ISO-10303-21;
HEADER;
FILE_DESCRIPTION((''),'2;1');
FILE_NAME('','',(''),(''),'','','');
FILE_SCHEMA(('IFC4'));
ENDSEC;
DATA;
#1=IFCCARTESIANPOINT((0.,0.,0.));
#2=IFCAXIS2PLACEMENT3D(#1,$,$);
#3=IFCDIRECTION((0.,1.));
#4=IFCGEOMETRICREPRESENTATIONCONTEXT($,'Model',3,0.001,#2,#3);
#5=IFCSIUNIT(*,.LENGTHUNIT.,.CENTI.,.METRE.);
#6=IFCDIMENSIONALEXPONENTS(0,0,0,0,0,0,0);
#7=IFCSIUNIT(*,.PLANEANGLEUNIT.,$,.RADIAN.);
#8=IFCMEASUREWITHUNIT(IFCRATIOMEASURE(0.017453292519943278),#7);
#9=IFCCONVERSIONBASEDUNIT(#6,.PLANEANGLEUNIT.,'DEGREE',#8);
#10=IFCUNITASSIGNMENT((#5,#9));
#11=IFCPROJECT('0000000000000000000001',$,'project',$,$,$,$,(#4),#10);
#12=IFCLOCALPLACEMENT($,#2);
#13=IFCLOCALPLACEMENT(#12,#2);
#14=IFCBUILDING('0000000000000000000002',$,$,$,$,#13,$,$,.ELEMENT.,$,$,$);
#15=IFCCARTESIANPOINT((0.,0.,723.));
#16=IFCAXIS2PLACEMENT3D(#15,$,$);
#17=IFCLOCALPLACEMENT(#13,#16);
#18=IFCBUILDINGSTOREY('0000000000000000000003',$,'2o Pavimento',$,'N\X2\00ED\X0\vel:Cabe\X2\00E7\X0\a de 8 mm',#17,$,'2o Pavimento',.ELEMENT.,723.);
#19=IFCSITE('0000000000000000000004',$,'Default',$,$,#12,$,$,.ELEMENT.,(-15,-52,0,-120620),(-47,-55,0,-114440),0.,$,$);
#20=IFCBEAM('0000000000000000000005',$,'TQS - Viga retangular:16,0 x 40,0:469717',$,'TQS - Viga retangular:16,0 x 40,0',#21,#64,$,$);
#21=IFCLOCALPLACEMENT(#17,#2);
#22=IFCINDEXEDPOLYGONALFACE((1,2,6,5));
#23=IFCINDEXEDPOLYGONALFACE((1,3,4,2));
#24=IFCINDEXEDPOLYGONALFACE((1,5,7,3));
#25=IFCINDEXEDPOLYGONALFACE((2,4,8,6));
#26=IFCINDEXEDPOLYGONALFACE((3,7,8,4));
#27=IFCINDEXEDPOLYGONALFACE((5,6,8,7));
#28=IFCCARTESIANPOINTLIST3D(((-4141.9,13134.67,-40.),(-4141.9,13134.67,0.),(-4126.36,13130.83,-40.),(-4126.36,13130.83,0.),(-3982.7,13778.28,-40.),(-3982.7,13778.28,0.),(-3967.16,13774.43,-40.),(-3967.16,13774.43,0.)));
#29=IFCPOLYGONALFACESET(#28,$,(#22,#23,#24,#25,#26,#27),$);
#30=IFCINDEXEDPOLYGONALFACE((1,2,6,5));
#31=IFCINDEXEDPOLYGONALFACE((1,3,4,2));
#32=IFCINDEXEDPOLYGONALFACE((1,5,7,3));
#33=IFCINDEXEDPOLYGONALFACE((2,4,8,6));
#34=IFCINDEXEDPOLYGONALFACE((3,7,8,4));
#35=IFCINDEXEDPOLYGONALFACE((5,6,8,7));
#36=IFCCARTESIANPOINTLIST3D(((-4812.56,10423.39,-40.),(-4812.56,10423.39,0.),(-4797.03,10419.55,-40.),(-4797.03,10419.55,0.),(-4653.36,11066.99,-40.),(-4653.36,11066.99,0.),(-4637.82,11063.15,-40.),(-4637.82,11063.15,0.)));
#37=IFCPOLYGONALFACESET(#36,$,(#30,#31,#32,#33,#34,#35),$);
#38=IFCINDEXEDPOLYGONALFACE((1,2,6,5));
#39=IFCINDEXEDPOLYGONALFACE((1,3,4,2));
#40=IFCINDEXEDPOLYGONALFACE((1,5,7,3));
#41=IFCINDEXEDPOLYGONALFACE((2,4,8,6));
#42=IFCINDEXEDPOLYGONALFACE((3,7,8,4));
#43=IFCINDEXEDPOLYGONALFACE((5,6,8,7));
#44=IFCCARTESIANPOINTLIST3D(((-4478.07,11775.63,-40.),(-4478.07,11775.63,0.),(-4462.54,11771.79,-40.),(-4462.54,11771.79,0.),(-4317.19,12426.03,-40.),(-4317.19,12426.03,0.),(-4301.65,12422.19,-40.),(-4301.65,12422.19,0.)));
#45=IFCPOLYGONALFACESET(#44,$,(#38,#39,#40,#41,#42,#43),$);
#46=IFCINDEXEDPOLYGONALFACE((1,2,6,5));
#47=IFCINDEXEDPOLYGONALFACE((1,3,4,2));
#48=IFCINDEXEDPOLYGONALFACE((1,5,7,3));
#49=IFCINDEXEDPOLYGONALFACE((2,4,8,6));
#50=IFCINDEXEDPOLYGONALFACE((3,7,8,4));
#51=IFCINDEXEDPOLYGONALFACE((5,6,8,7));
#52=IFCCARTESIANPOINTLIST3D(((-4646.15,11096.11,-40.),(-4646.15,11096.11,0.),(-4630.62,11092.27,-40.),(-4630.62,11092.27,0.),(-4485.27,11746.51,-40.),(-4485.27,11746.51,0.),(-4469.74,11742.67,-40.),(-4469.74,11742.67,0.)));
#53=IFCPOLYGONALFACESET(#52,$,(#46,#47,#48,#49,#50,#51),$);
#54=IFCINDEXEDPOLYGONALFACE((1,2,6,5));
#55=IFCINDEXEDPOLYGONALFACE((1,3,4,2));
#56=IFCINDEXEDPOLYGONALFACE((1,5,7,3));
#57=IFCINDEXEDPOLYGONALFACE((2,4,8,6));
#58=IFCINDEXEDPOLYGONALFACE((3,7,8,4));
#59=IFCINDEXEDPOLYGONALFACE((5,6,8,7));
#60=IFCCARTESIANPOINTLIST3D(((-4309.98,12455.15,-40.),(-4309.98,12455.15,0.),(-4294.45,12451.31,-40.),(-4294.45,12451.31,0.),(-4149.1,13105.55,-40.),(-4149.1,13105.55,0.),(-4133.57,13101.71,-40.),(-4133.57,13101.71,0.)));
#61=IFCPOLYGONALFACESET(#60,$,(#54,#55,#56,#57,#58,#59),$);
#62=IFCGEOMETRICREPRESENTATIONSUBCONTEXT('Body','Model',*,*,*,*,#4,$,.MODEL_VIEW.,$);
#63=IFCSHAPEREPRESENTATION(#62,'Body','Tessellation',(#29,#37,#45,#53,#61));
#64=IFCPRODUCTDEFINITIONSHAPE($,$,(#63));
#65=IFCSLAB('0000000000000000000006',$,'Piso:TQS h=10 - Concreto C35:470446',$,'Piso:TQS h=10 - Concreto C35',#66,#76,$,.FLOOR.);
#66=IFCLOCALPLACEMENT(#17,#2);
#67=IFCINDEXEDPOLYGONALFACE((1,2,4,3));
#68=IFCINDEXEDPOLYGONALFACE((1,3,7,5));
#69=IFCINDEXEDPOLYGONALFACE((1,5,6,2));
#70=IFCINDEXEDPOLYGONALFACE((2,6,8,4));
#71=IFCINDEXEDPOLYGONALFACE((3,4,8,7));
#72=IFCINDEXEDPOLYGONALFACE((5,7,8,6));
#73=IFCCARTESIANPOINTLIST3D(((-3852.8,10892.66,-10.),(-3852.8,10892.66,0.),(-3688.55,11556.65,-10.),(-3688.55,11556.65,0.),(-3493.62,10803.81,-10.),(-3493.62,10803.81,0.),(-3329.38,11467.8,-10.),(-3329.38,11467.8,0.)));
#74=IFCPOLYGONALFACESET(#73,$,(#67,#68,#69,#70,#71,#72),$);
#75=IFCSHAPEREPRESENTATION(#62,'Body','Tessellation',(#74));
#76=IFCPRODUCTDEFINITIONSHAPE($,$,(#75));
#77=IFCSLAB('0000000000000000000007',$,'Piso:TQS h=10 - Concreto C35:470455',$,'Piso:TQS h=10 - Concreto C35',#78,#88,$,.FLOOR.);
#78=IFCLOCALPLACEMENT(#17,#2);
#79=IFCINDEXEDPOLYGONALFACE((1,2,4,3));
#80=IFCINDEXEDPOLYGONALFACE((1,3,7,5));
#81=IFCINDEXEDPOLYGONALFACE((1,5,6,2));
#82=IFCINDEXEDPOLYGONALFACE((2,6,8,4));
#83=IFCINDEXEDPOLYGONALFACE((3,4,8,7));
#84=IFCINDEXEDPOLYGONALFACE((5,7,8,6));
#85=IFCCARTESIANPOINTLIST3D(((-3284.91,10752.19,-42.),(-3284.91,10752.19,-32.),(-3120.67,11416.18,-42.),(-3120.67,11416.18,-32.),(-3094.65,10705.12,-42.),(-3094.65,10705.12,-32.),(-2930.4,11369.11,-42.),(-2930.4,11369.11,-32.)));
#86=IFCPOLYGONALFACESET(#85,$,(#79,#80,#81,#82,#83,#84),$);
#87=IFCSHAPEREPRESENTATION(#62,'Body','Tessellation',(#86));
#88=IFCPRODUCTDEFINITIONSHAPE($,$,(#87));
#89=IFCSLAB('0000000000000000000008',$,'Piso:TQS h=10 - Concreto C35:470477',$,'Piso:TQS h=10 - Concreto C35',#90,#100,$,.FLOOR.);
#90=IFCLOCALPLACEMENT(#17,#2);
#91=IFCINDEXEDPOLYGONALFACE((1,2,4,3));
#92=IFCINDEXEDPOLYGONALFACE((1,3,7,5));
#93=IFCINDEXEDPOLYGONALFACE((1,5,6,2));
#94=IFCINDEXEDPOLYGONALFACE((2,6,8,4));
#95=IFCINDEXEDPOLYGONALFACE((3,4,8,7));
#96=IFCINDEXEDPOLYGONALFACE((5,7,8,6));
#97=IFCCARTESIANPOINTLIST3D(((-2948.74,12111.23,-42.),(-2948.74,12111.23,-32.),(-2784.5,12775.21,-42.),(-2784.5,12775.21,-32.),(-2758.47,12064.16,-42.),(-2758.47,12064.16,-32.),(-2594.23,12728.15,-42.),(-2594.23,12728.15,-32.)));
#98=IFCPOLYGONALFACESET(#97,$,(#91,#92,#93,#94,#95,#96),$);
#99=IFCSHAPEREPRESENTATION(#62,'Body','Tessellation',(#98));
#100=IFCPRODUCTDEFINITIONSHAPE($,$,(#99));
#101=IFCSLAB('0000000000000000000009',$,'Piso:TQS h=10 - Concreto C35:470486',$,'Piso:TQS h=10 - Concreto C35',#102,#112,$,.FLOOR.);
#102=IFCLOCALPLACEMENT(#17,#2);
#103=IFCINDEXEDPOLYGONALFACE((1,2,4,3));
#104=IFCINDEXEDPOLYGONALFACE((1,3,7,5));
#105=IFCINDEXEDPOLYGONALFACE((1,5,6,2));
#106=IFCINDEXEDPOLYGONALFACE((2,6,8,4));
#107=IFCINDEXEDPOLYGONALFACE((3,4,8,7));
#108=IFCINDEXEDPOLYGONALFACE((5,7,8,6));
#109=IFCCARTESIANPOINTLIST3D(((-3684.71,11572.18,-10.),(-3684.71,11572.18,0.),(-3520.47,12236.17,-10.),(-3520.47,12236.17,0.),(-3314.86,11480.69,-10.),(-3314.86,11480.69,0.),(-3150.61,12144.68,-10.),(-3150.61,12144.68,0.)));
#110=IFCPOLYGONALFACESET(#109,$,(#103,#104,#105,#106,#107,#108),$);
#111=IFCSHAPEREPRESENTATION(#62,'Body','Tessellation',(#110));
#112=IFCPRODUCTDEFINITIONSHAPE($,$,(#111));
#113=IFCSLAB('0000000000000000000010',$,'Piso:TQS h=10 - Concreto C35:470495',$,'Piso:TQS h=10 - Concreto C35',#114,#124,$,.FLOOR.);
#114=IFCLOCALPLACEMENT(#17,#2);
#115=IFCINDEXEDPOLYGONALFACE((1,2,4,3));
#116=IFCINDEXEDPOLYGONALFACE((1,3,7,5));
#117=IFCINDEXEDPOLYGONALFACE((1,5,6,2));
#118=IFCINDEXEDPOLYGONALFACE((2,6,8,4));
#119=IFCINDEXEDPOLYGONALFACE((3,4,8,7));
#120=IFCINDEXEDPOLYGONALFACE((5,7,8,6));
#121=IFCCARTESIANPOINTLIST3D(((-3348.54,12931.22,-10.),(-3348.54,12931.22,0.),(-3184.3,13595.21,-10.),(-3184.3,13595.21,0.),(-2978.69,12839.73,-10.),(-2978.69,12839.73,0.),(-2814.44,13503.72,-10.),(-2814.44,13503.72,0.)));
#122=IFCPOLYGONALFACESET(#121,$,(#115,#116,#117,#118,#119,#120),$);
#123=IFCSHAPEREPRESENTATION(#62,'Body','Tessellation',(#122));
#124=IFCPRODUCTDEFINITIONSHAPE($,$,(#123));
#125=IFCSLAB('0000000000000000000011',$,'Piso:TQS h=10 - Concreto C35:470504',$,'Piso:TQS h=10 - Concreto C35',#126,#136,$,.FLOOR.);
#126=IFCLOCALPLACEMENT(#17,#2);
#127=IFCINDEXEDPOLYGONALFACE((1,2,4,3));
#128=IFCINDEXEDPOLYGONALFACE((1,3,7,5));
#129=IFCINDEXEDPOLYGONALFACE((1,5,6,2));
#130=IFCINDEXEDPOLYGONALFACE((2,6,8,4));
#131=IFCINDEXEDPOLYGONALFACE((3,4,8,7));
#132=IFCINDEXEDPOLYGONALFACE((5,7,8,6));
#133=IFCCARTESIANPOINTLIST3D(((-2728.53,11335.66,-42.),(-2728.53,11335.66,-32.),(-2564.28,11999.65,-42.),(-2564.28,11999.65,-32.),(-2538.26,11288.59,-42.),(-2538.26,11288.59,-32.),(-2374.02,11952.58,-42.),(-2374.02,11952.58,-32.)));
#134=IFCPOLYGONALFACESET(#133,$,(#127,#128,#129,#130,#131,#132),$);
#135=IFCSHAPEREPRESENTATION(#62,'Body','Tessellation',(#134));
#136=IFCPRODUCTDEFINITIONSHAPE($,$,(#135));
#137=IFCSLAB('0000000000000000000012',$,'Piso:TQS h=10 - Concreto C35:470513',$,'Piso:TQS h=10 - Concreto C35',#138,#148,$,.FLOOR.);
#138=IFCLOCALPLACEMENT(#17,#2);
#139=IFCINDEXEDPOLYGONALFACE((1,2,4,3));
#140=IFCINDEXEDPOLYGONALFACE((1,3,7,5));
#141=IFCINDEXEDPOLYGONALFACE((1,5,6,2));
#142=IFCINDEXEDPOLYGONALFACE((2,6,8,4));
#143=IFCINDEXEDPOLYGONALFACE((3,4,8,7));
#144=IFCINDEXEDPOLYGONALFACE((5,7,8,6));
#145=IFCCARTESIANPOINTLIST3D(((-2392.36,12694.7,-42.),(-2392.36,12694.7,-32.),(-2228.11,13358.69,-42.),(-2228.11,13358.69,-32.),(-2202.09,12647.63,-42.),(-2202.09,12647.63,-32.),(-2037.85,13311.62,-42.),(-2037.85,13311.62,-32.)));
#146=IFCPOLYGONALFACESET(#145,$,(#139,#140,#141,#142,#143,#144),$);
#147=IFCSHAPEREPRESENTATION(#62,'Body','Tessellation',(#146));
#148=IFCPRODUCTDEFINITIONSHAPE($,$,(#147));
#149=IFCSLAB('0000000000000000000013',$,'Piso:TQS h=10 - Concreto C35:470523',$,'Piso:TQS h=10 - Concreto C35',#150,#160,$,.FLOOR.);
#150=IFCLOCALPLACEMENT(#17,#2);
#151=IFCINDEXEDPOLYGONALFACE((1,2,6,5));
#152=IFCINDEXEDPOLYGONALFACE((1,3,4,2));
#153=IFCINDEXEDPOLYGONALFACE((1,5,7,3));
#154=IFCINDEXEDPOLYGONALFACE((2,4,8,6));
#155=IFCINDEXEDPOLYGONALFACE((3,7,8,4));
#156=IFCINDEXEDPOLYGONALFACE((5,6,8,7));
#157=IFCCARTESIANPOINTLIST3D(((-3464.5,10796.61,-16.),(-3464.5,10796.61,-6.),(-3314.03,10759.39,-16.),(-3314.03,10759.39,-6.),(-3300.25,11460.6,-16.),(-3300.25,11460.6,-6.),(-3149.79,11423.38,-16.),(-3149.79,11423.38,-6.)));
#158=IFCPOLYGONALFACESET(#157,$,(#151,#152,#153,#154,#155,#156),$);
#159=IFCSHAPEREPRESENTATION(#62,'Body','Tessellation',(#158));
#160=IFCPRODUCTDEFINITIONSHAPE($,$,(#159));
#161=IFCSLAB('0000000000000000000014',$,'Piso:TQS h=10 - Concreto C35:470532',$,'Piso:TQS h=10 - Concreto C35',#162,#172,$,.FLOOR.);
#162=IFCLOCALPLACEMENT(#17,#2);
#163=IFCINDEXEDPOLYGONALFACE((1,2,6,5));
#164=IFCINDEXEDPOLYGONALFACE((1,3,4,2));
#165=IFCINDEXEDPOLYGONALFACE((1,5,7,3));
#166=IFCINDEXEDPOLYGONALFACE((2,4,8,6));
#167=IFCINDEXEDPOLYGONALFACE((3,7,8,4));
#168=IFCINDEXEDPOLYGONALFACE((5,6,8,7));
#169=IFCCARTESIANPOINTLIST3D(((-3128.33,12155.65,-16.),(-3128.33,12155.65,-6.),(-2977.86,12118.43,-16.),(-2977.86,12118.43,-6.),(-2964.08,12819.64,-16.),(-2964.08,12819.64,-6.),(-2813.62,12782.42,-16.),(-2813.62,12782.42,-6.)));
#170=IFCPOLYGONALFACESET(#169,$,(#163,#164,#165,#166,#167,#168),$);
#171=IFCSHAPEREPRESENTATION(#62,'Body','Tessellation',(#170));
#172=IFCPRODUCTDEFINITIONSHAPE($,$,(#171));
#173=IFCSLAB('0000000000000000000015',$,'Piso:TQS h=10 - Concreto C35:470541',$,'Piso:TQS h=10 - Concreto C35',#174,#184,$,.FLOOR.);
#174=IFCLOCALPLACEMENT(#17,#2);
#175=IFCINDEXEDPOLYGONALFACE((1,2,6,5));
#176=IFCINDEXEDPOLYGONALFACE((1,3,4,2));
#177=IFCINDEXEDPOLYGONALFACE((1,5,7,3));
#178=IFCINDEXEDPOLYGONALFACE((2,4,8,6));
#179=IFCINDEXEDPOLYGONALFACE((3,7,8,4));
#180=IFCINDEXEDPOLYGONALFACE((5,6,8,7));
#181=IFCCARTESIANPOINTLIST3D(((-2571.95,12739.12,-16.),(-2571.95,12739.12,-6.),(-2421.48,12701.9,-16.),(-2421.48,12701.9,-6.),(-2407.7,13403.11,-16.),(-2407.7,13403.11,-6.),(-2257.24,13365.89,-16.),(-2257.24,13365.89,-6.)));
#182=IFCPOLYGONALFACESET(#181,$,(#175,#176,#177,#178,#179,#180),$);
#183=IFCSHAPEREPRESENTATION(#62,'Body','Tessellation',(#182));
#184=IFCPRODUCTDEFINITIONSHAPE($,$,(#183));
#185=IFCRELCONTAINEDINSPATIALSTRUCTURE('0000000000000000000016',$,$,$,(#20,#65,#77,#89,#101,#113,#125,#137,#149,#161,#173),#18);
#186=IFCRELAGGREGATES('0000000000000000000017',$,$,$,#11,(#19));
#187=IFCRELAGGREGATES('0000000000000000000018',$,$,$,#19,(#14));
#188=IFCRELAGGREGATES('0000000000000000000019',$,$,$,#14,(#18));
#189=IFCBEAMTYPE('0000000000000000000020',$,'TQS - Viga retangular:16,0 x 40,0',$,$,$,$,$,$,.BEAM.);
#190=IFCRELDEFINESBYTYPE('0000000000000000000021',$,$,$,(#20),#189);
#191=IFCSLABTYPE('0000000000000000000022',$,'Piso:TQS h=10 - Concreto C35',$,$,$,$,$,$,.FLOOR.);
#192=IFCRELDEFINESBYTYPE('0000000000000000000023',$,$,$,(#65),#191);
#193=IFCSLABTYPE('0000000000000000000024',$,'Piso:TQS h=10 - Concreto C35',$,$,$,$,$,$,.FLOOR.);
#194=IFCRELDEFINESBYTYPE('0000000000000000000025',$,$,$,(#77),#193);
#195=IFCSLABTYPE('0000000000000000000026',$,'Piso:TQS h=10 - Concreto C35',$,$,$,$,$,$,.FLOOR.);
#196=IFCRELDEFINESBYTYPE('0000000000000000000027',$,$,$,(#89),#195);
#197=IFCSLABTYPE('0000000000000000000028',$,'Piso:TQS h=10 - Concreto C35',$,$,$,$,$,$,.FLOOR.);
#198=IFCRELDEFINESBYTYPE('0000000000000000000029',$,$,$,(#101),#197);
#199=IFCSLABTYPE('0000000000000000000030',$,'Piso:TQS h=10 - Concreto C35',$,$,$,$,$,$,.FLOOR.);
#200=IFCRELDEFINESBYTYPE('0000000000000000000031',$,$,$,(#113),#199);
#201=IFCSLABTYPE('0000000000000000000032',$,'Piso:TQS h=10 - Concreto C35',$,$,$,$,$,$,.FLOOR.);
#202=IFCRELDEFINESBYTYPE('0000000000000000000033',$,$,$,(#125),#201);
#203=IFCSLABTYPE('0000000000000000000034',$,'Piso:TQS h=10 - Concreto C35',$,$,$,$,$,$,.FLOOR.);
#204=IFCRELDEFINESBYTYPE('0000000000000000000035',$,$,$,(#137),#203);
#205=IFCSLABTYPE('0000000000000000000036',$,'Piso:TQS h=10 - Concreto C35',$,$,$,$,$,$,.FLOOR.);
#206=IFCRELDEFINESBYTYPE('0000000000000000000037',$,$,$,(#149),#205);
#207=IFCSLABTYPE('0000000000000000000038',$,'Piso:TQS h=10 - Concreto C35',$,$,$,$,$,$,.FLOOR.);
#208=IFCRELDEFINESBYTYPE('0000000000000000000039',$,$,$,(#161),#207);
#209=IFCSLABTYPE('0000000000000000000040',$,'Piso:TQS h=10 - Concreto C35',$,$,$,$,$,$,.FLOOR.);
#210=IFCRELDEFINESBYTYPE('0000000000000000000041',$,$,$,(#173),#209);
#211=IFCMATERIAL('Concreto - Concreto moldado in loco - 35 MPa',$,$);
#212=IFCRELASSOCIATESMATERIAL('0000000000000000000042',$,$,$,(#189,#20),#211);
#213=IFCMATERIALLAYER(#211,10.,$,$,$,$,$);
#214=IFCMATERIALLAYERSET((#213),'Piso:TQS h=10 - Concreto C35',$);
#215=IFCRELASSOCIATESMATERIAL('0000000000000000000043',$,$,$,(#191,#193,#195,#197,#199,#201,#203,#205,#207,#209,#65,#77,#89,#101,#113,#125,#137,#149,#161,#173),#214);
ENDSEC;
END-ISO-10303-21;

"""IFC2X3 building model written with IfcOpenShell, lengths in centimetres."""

from ifc_helpers import new_model, entity, si_unit, converted_unit, direction, frame, frame_2d, origin, origin_2d_with_axis, place, context, subcontext, project, spatial, rectangle, extrude, source, transform, mapped, material, layer, layer_set, layer_usage, type_object, type_shapes, element, save


model = new_model("IFC2X3")

# Units and contexts
model_context = context("Model", 3, precision=0.001, world=origin(), true_north=direction((0.0, 1.0)))
body_context = subcontext(model_context, "Body", "Model", "MODEL_VIEW")
ifc_project = project(units=[si_unit("LENGTHUNIT", "METRE", prefix="CENTI"), converted_unit("PLANEANGLEUNIT", "DEGREE", entity("IfcRatioMeasure", 0.017453292519943278), si_unit("PLANEANGLEUNIT", "RADIAN"), dimensions=[0, 0, 0, 0, 0, 0, 0])], contexts=[model_context])

# Site, building, storey
site_placement = place(None, origin())
site = spatial("IfcSite", under=ifc_project, at=site_placement, Name="Default", CompositionType="ELEMENT", RefLatitude=(-15, -52, 0, -120620), RefLongitude=(-47, -55, 0, -114440), RefElevation=0.0)
building_placement = place(site_placement, origin())
building = spatial("IfcBuilding", under=site, at=building_placement, CompositionType="ELEMENT")
storey_placement = place(building_placement, frame((0.0, 0.0, 723.0)))
storey = spatial("IfcBuildingStorey", under=building, at=storey_placement, Name="2o Pavimento", ObjectType="Nível:Cabeça de 8 mm", LongName="2o Pavimento", CompositionType="ELEMENT", Elevation=723.0)

# Beam
ifc_material = material(Name="Concreto - Concreto moldado in loco - 35 MPa")
beam_type_1 = type_object("IfcBeamType", Name="TQS - Viga retangular:16,0 x 40,0", PredefinedType="BEAM", material=ifc_material)
shared_shape_1 = source(origin(), body_context, "Body", "SweptSolid", [
    extrude(rectangle(XDim=40.0, YDim=16.0, at=frame_2d((0.0, 0.0), x_axis=(1.0, 0.0))), frame((-4134.13, 13132.75, 703.0), z_axis=(0.240122, 0.970743, 0.0), x_axis=(0.0, 0.0, 1.0)), (0.0, 0.0, 1.0), 663.0),
    extrude(rectangle(XDim=40.0, YDim=16.0, at=frame_2d((0.0, 0.0), x_axis=(1.0, 0.0))), frame((-4804.79, 10421.47, 703.0), z_axis=(0.240122, 0.970743, 0.0), x_axis=(0.0, 0.0, 1.0)), (0.0, 0.0, 1.0), 663.0),
    extrude(rectangle(XDim=40.0, YDim=16.0, at=frame_2d((0.0, 0.0), x_axis=(1.0, 0.0))), frame((-4470.3, 11773.71, 703.0), z_axis=(0.240122, 0.970743, 0.0), x_axis=(0.0, 0.0, 1.0)), (0.0, 0.0, 1.0), 670.0),
    extrude(rectangle(XDim=40.0, YDim=16.0, at=frame_2d((0.0, 0.0), x_axis=(1.0, 0.0))), frame((-4638.39, 11094.19, 703.0), z_axis=(0.240122, 0.970743, 0.0), x_axis=(0.0, 0.0, 1.0)), (0.0, 0.0, 1.0), 670.0),
    extrude(rectangle(XDim=40.0, YDim=16.0, at=frame_2d((0.0, 0.0), x_axis=(1.0, 0.0))), frame((-4302.22, 12453.23, 703.0), z_axis=(0.240122, 0.970743, 0.0), x_axis=(0.0, 0.0, 1.0)), (0.0, 0.0, 1.0), 670.0),
])
type_shapes(beam_type_1, [shared_shape_1])
beam_1_placement = place(storey_placement, frame((0.0, 0.0, -723.0)))
element("IfcBeam", 1, at=beam_1_placement, inside=storey, type_object=beam_type_1, material=ifc_material, Name="TQS - Viga retangular:16,0 x 40,0:469717", ObjectType="TQS - Viga retangular:16,0 x 40,0", context=body_context, shape_type="MappedRepresentation", body=[
    mapped(shared_shape_1, transform((0.0, 0.0, 0.0), scale=1.0)),
])

# Slabs
ifc_layer = layer(ifc_material, 10.0)
ifc_layer_set = layer_set([ifc_layer], Name="Piso:TQS h=10 - Concreto C35")
ifc_layer_usage_1 = layer_usage(ifc_layer_set, "AXIS3", "POSITIVE", 0.0)
slab_type_1 = type_object("IfcSlabType", Name="Piso:TQS h=10 - Concreto C35", PredefinedType="FLOOR", material=ifc_layer_set)
slab_1_placement = place(storey_placement, origin())
element("IfcSlab", 2, at=slab_1_placement, inside=storey, type_object=slab_type_1, material=ifc_layer_usage_1, Name="Piso:TQS h=10 - Concreto C35:470446", ObjectType="Piso:TQS h=10 - Concreto C35", PredefinedType="FLOOR", context=body_context, shape_type="SweptSolid", body=[
    extrude(rectangle(XDim=684.0, YDim=370.0, at=frame_2d((0.0, 0.0), x_axis=(1.0, 0.0))), frame((-3591.09, 11180.23, 0.0), z_axis=(0.0, 0.0, -1.0), x_axis=(-0.240122, -0.970743, 0.0)), (0.0, 0.0, 1.0), 10.0),
])
ifc_layer_usage_2 = layer_usage(ifc_layer_set, "AXIS3", "POSITIVE", 0.0)
slab_type_2 = type_object("IfcSlabType", Name="Piso:TQS h=10 - Concreto C35", PredefinedType="FLOOR", material=ifc_layer_set)
slab_2_placement = place(storey_placement, origin())
element("IfcSlab", 3, at=slab_2_placement, inside=storey, type_object=slab_type_2, material=ifc_layer_usage_2, Name="Piso:TQS h=10 - Concreto C35:470455", ObjectType="Piso:TQS h=10 - Concreto C35", PredefinedType="FLOOR", context=body_context, shape_type="SweptSolid", body=[
    extrude(rectangle(XDim=684.0, YDim=196.0, at=frame_2d((0.0, 0.0), x_axis=(1.0, 0.0))), frame((-3107.66, 11060.65, -32.0), z_axis=(0.0, 0.0, -1.0), x_axis=(-0.240122, -0.970743, 0.0)), (0.0, 0.0, 1.0), 10.0),
])
ifc_layer_usage_3 = layer_usage(ifc_layer_set, "AXIS3", "POSITIVE", 0.0)
slab_type_3 = type_object("IfcSlabType", Name="Piso:TQS h=10 - Concreto C35", PredefinedType="FLOOR", material=ifc_layer_set)
slab_3_placement = place(storey_placement, origin())
element("IfcSlab", 4, at=slab_3_placement, inside=storey, type_object=slab_type_3, material=ifc_layer_usage_3, Name="Piso:TQS h=10 - Concreto C35:470477", ObjectType="Piso:TQS h=10 - Concreto C35", PredefinedType="FLOOR", context=body_context, shape_type="SweptSolid", body=[
    extrude(rectangle(XDim=684.0, YDim=196.0, at=frame_2d((0.0, 0.0), x_axis=(1.0, 0.0))), frame((-2771.49, 12419.69, -32.0), z_axis=(0.0, 0.0, -1.0), x_axis=(-0.240122, -0.970743, 0.0)), (0.0, 0.0, 1.0), 10.0),
])
ifc_layer_usage_4 = layer_usage(ifc_layer_set, "AXIS3", "POSITIVE", 0.0)
slab_type_4 = type_object("IfcSlabType", Name="Piso:TQS h=10 - Concreto C35", PredefinedType="FLOOR", material=ifc_layer_set)
slab_4_placement = place(storey_placement, origin())
element("IfcSlab", 5, at=slab_4_placement, inside=storey, type_object=slab_type_4, material=ifc_layer_usage_4, Name="Piso:TQS h=10 - Concreto C35:470486", ObjectType="Piso:TQS h=10 - Concreto C35", PredefinedType="FLOOR", context=body_context, shape_type="SweptSolid", body=[
    extrude(rectangle(XDim=684.0, YDim=381.0, at=frame_2d((0.0, 0.0), x_axis=(1.0, 0.0))), frame((-3417.66, 11858.43, 0.0), z_axis=(0.0, 0.0, -1.0), x_axis=(-0.240122, -0.970743, 0.0)), (0.0, 0.0, 1.0), 10.0),
])
ifc_layer_usage_5 = layer_usage(ifc_layer_set, "AXIS3", "POSITIVE", 0.0)
slab_type_5 = type_object("IfcSlabType", Name="Piso:TQS h=10 - Concreto C35", PredefinedType="FLOOR", material=ifc_layer_set)
slab_5_placement = place(storey_placement, origin())
element("IfcSlab", 6, at=slab_5_placement, inside=storey, type_object=slab_type_5, material=ifc_layer_usage_5, Name="Piso:TQS h=10 - Concreto C35:470495", ObjectType="Piso:TQS h=10 - Concreto C35", PredefinedType="FLOOR", context=body_context, shape_type="SweptSolid", body=[
    extrude(rectangle(XDim=381.0, YDim=684.0, at=origin_2d_with_axis()), frame((-3081.49, 13217.47, 0.0), z_axis=(0.0, 0.0, -1.0), x_axis=(0.970743, -0.240122, 0.0)), (0.0, 0.0, 1.0), 10.0),
])
ifc_layer_usage_6 = layer_usage(ifc_layer_set, "AXIS3", "POSITIVE", 0.0)
slab_type_6 = type_object("IfcSlabType", Name="Piso:TQS h=10 - Concreto C35", PredefinedType="FLOOR", material=ifc_layer_set)
slab_6_placement = place(storey_placement, origin())
element("IfcSlab", 7, at=slab_6_placement, inside=storey, type_object=slab_type_6, material=ifc_layer_usage_6, Name="Piso:TQS h=10 - Concreto C35:470504", ObjectType="Piso:TQS h=10 - Concreto C35", PredefinedType="FLOOR", context=body_context, shape_type="SweptSolid", body=[
    extrude(rectangle(XDim=684.0, YDim=196.0, at=frame_2d((0.0, 0.0), x_axis=(1.0, 0.0))), frame((-2551.27, 11644.12, -32.0), z_axis=(0.0, 0.0, -1.0), x_axis=(-0.240122, -0.970743, 0.0)), (0.0, 0.0, 1.0), 10.0),
])
ifc_layer_usage_7 = layer_usage(ifc_layer_set, "AXIS3", "POSITIVE", 0.0)
slab_type_7 = type_object("IfcSlabType", Name="Piso:TQS h=10 - Concreto C35", PredefinedType="FLOOR", material=ifc_layer_set)
slab_7_placement = place(storey_placement, origin())
element("IfcSlab", 8, at=slab_7_placement, inside=storey, type_object=slab_type_7, material=ifc_layer_usage_7, Name="Piso:TQS h=10 - Concreto C35:470513", ObjectType="Piso:TQS h=10 - Concreto C35", PredefinedType="FLOOR", context=body_context, shape_type="SweptSolid", body=[
    extrude(rectangle(XDim=684.0, YDim=196.0, at=frame_2d((0.0, 0.0), x_axis=(1.0, 0.0))), frame((-2215.1, 13003.16, -32.0), z_axis=(0.0, 0.0, -1.0), x_axis=(-0.240122, -0.970743, 0.0)), (0.0, 0.0, 1.0), 10.0),
])
ifc_layer_usage_8 = layer_usage(ifc_layer_set, "AXIS3", "POSITIVE", 0.0)
slab_type_8 = type_object("IfcSlabType", Name="Piso:TQS h=10 - Concreto C35", PredefinedType="FLOOR", material=ifc_layer_set)
slab_8_placement = place(storey_placement, origin())
element("IfcSlab", 9, at=slab_8_placement, inside=storey, type_object=slab_type_8, material=ifc_layer_usage_8, Name="Piso:TQS h=10 - Concreto C35:470523", ObjectType="Piso:TQS h=10 - Concreto C35", PredefinedType="FLOOR", context=body_context, shape_type="SweptSolid", body=[
    extrude(rectangle(XDim=684.0, YDim=155.0, at=frame_2d((0.0, 0.0), x_axis=(1.0, 0.0))), frame((-3307.14, 11109.99, -6.0), z_axis=(0.0, 0.0, -1.0), x_axis=(-0.240122, -0.970743, 0.0)), (0.0, 0.0, 1.0), 10.0),
])
ifc_layer_usage_9 = layer_usage(ifc_layer_set, "AXIS3", "POSITIVE", 0.0)
slab_type_9 = type_object("IfcSlabType", Name="Piso:TQS h=10 - Concreto C35", PredefinedType="FLOOR", material=ifc_layer_set)
slab_9_placement = place(storey_placement, origin())
element("IfcSlab", 10, at=slab_9_placement, inside=storey, type_object=slab_type_9, material=ifc_layer_usage_9, Name="Piso:TQS h=10 - Concreto C35:470532", ObjectType="Piso:TQS h=10 - Concreto C35", PredefinedType="FLOOR", context=body_context, shape_type="SweptSolid", body=[
    extrude(rectangle(XDim=684.0, YDim=155.0, at=frame_2d((0.0, 0.0), x_axis=(1.0, 0.0))), frame((-2970.97, 12469.03, -6.0), z_axis=(0.0, 0.0, -1.0), x_axis=(-0.240122, -0.970743, 0.0)), (0.0, 0.0, 1.0), 10.0),
])
ifc_layer_usage_10 = layer_usage(ifc_layer_set, "AXIS3", "POSITIVE", 0.0)
slab_type_10 = type_object("IfcSlabType", Name="Piso:TQS h=10 - Concreto C35", PredefinedType="FLOOR", material=ifc_layer_set)
slab_10_placement = place(storey_placement, origin())
element("IfcSlab", 11, at=slab_10_placement, inside=storey, type_object=slab_type_10, material=ifc_layer_usage_10, Name="Piso:TQS h=10 - Concreto C35:470541", ObjectType="Piso:TQS h=10 - Concreto C35", PredefinedType="FLOOR", context=body_context, shape_type="SweptSolid", body=[
    extrude(rectangle(XDim=684.0, YDim=155.0, at=origin_2d_with_axis()), frame((-2414.59, 13052.5, -6.0), z_axis=(0.0, 0.0, -1.0), x_axis=(-0.240122, -0.970743, 0.0)), (0.0, 0.0, 1.0), 10.0),
])

save(model, "model.ifc")
